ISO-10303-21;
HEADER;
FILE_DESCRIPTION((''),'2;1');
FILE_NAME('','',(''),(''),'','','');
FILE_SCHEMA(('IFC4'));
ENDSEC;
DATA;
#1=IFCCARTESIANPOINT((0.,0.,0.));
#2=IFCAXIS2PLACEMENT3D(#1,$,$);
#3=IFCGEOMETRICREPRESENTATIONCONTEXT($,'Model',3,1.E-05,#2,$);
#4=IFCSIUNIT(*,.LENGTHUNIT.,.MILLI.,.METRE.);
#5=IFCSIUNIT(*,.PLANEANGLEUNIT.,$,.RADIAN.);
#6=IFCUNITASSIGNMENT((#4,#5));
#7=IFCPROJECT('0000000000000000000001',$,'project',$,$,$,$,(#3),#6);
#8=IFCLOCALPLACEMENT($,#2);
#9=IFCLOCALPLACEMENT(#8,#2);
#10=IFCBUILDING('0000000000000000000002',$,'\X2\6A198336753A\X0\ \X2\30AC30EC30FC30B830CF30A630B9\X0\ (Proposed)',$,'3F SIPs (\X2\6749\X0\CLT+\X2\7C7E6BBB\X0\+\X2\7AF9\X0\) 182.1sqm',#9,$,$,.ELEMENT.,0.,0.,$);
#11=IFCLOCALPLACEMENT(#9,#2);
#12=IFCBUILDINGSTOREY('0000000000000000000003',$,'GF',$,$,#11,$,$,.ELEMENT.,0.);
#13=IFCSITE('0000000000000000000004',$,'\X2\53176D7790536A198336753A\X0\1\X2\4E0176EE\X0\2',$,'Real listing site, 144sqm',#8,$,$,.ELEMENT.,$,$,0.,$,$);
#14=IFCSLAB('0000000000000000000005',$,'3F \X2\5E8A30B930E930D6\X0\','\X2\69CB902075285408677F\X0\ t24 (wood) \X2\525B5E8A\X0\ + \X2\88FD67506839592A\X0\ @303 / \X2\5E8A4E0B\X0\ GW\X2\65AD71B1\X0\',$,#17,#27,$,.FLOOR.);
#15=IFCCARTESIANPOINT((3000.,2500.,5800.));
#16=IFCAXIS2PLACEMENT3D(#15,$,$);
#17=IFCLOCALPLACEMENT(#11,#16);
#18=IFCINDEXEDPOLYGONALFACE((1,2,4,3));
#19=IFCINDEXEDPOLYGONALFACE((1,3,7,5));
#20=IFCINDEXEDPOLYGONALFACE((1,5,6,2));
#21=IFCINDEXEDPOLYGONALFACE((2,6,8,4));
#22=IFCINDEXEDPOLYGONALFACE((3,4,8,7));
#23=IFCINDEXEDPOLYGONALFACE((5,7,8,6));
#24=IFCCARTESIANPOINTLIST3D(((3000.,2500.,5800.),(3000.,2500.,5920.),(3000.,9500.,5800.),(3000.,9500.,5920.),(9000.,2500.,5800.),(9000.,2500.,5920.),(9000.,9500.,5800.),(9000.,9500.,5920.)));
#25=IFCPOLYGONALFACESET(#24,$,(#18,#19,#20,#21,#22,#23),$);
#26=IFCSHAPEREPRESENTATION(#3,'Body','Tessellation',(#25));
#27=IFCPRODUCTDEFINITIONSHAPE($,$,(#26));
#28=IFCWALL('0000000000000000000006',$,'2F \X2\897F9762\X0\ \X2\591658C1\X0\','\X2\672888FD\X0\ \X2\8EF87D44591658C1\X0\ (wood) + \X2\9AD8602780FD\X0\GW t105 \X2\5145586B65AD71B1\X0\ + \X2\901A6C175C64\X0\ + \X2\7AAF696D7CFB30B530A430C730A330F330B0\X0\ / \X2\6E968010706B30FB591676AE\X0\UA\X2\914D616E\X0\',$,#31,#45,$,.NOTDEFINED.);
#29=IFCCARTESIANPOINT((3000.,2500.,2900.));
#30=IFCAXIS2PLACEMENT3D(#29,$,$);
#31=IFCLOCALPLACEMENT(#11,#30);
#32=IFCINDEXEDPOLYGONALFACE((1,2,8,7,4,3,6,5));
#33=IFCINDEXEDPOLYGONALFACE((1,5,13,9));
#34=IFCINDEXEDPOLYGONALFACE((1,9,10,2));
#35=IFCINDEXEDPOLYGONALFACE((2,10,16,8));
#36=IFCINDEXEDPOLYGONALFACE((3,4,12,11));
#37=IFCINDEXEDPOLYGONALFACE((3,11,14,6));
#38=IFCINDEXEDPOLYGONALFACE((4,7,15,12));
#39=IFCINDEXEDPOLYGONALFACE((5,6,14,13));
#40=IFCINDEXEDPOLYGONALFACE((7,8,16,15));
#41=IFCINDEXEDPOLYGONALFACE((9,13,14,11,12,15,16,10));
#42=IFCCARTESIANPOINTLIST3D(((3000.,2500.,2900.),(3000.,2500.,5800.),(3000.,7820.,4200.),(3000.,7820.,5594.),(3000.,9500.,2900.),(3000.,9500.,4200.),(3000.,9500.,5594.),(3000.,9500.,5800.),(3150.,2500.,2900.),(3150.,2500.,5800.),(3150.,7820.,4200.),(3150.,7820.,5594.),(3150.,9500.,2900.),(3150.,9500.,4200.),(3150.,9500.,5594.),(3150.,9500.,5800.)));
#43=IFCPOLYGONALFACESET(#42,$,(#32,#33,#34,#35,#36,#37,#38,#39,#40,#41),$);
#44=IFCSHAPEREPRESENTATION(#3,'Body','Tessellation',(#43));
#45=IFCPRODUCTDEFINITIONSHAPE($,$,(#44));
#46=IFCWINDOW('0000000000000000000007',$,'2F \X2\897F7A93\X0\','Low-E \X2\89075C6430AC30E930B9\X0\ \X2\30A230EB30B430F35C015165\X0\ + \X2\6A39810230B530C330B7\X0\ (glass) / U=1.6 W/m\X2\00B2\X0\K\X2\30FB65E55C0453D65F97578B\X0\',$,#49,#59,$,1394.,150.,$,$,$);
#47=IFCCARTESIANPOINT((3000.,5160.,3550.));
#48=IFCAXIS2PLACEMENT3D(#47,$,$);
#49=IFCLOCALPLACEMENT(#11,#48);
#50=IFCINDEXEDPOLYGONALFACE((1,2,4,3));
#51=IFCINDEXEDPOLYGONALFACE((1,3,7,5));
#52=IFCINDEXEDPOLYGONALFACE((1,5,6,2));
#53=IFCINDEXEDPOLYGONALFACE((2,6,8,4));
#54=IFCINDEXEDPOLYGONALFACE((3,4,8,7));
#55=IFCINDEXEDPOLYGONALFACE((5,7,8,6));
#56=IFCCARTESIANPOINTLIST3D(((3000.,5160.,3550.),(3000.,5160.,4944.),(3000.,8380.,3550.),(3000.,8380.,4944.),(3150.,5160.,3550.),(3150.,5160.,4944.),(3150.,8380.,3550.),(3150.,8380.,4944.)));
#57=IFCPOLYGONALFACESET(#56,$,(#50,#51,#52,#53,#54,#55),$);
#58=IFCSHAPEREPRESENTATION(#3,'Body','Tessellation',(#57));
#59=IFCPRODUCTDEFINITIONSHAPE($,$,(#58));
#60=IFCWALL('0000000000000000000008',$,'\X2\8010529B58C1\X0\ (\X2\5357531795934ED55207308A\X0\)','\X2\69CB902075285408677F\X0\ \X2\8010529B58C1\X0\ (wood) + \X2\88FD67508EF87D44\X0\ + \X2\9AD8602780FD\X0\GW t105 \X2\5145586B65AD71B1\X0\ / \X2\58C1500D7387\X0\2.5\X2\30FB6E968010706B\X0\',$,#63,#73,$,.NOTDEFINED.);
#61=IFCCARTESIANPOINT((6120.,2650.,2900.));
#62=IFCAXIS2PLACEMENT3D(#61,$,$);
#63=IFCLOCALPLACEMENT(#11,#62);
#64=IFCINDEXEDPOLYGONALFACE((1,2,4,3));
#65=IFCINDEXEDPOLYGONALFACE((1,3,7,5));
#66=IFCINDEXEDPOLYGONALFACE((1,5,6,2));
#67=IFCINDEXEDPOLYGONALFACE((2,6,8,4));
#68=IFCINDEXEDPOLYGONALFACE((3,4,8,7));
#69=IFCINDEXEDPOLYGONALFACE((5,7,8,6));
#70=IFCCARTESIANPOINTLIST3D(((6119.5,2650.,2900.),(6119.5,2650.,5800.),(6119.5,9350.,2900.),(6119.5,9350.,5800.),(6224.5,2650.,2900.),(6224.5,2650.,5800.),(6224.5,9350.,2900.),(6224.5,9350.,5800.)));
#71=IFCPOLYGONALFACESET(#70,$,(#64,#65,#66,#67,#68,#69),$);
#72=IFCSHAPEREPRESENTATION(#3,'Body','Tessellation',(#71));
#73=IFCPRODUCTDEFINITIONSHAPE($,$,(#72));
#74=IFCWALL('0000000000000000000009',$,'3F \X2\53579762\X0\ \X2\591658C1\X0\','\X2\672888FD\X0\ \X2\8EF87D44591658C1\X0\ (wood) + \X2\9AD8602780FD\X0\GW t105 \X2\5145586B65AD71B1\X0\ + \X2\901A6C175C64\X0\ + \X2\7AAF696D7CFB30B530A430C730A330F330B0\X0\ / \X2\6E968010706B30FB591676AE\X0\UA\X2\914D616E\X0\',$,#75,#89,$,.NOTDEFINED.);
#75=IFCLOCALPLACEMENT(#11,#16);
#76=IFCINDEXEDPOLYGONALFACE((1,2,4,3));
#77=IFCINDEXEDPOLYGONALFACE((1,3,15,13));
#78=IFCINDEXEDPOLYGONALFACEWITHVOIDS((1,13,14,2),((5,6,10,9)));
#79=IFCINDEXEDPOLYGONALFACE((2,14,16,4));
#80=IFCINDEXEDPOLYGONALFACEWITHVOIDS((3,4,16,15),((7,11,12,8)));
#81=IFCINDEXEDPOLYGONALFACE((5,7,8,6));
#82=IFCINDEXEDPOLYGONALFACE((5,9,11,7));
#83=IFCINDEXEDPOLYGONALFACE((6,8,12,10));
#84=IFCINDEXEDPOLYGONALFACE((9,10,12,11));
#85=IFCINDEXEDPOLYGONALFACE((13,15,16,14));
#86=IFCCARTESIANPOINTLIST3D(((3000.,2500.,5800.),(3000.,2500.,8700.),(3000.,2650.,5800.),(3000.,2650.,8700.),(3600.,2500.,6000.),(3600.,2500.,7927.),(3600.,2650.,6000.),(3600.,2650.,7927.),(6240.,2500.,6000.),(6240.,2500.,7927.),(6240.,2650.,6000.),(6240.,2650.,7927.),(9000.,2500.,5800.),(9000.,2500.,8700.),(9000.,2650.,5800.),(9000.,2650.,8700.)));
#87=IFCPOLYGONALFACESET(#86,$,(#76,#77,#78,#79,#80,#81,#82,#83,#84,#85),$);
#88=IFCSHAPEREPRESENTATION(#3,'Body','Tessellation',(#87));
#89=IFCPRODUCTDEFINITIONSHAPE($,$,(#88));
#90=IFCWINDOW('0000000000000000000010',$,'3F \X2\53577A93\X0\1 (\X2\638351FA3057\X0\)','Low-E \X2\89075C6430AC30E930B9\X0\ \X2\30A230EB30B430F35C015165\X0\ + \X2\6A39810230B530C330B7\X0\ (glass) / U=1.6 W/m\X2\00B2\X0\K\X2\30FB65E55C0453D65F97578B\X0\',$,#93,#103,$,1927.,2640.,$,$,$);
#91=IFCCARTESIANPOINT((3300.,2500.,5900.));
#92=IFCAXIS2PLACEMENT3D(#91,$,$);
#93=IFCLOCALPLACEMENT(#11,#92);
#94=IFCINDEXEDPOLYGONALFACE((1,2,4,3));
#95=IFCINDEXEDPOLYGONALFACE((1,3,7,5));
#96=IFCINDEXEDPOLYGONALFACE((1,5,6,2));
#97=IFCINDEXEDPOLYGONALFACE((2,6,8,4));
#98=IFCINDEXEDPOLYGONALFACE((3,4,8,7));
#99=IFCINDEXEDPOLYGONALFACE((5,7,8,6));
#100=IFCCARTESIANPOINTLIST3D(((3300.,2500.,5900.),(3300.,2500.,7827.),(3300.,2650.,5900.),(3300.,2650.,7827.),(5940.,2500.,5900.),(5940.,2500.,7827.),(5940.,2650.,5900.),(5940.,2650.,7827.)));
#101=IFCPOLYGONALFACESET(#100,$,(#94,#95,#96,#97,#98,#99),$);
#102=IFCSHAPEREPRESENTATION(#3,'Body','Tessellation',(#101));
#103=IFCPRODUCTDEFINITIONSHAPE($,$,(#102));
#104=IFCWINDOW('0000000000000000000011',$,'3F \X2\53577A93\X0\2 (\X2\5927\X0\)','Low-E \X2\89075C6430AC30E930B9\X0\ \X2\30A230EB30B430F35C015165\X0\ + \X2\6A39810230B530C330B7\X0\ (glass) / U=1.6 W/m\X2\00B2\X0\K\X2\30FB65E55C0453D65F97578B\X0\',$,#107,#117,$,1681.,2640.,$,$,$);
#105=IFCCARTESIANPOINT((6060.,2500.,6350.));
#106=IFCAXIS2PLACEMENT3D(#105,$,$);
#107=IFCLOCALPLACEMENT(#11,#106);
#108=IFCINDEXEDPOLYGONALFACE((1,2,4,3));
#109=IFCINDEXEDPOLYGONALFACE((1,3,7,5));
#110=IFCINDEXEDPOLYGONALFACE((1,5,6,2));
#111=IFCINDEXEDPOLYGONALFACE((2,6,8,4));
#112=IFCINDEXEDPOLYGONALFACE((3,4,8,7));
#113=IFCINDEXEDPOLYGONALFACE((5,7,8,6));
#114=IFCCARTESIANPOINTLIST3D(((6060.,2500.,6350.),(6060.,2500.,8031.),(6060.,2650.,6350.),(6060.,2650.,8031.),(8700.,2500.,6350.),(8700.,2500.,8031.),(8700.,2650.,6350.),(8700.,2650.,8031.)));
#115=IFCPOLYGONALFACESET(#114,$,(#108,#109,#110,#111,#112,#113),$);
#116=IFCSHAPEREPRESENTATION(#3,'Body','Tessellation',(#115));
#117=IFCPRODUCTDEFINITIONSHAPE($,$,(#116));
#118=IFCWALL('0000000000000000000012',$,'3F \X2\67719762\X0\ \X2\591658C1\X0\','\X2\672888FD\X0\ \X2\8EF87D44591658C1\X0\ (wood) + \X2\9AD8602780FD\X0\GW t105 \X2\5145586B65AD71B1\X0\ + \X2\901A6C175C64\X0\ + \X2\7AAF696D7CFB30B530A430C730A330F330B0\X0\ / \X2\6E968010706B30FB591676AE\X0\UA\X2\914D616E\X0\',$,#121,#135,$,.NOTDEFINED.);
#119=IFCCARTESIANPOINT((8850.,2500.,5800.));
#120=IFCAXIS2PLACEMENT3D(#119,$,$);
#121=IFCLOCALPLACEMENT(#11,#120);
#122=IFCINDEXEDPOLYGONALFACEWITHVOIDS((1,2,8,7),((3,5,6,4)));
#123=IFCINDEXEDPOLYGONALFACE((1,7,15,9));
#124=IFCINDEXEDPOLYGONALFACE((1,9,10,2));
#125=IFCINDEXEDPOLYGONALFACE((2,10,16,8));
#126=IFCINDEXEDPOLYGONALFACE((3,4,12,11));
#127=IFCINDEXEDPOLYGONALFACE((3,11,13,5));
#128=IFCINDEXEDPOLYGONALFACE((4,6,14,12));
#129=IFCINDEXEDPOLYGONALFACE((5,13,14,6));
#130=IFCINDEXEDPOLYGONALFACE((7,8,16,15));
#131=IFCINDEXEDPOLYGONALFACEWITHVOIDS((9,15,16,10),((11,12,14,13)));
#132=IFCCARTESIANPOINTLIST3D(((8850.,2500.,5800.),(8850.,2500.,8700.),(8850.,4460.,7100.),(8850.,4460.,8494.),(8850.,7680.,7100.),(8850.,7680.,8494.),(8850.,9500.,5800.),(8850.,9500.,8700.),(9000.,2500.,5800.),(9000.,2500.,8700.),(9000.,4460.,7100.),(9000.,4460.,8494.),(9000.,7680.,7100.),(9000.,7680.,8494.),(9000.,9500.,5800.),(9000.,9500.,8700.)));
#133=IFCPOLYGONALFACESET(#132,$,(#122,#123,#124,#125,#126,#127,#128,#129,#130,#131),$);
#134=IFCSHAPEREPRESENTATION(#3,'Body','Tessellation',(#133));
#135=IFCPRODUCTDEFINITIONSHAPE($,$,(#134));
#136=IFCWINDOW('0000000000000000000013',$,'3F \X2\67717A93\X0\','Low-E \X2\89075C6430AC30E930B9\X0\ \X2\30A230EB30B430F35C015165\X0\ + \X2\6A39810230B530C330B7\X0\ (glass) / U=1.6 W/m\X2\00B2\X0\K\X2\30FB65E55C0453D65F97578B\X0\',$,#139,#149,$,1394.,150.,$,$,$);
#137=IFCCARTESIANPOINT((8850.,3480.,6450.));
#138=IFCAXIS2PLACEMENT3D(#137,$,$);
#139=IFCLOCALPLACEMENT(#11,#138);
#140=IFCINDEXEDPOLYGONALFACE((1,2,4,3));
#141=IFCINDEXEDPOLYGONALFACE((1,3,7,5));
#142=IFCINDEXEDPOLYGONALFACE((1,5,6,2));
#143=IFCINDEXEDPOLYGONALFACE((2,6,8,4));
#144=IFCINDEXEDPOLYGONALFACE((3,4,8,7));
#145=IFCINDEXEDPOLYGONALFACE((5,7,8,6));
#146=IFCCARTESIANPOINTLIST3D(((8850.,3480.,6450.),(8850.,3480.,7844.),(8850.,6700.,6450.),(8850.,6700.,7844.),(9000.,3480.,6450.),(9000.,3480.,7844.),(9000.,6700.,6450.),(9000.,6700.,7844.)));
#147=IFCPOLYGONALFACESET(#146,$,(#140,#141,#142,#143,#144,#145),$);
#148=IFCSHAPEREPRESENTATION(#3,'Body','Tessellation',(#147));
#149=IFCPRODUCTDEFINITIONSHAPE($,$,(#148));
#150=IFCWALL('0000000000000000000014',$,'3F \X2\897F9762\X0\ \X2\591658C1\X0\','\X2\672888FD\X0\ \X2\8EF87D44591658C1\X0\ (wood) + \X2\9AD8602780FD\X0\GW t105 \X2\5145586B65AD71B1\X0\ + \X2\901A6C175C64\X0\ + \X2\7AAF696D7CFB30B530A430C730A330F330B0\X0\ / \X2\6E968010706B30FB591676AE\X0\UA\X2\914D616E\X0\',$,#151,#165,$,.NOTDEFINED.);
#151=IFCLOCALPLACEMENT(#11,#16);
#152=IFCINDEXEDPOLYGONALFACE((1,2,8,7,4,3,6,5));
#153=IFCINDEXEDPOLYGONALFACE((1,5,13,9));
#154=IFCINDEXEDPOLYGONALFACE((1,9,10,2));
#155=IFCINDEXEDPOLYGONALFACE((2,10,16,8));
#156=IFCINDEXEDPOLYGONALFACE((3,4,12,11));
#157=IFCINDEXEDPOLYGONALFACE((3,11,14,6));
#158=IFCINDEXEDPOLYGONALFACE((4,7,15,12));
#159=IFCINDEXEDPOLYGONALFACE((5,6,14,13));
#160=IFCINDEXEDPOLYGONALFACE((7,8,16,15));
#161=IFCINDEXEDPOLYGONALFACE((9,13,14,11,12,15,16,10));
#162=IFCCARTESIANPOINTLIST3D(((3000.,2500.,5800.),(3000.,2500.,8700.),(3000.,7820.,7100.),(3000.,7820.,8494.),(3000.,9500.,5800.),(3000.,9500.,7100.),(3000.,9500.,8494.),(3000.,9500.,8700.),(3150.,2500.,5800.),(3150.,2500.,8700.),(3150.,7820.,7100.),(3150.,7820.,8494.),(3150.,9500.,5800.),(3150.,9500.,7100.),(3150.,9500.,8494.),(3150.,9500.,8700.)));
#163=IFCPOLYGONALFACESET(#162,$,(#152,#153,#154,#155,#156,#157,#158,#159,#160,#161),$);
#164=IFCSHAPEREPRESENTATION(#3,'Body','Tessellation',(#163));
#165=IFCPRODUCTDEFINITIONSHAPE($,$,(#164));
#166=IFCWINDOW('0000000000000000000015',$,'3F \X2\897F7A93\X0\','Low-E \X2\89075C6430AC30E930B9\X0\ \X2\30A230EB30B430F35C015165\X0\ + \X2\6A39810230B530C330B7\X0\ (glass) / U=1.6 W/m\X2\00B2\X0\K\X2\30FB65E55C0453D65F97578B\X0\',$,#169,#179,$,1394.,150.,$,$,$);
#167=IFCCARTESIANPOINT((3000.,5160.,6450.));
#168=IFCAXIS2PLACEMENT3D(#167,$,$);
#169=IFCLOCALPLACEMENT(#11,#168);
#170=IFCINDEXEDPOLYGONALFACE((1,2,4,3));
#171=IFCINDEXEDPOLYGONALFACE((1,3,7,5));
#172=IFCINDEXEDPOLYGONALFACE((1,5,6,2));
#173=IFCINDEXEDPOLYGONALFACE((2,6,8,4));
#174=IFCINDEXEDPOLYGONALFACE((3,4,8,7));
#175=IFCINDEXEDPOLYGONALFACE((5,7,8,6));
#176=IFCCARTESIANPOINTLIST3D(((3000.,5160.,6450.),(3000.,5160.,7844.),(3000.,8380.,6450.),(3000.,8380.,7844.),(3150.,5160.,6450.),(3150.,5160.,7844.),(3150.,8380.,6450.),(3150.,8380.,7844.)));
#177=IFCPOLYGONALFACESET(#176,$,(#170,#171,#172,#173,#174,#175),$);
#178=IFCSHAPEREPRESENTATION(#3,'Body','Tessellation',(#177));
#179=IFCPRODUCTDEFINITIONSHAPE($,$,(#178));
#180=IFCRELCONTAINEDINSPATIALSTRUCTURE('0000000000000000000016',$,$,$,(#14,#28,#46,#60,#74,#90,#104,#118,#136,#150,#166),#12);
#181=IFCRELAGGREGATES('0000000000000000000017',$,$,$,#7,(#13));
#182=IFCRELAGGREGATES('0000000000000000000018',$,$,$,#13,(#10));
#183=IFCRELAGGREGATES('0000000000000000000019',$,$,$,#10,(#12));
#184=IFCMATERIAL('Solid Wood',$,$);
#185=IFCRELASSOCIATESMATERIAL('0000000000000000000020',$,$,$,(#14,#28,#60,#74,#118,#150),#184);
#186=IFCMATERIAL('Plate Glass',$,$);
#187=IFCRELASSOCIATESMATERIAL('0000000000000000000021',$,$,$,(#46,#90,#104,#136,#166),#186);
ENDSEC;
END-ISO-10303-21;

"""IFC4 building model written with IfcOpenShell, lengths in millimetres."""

from ifc_helpers import new_model, si_unit, frame, frame_2d, origin, place, context, project, spatial, rectangle, extrude, material, element, fill, save


model = new_model("IFC4")

# Units and contexts
model_context = context("Model", 3, precision=1e-05, world=origin())
ifc_project = project(units=[si_unit("LENGTHUNIT", "METRE", prefix="MILLI"), si_unit("PLANEANGLEUNIT", "RADIAN")], contexts=[model_context])

# Site, building, storey
site_placement = place(None, origin())
site = spatial("IfcSite", under=ifc_project, at=site_placement, Name="北海道標茶町1丁目2", ObjectType="Real listing site, 144sqm", CompositionType="ELEMENT", RefElevation=0.0)
building_placement = place(site_placement, origin())
building = spatial("IfcBuilding", under=site, at=building_placement, Name="標茶町 ガレージハウス (Proposed)", ObjectType="3F SIPs (杉CLT+籾殻+竹) 182.1sqm", CompositionType="ELEMENT", ElevationOfRefHeight=0.0, ElevationOfTerrain=0.0)
storey_placement = place(building_placement, origin())
storey = spatial("IfcBuildingStorey", under=building, at=storey_placement, Name="GF", CompositionType="ELEMENT", Elevation=0.0)

# Slab
ifc_material_1 = material(Name="Solid Wood")
slab_placement = place(storey_placement, frame((3000.0, 2500.0, 5800.0)))
element("IfcSlab", 1, at=slab_placement, inside=storey, material=ifc_material_1, Name="3F 床スラブ", Description="構造用合板 t24 (wood) 剛床 + 製材根太 @303 / 床下 GW断熱", PredefinedType="FLOOR", context=model_context, shape_type="SweptSolid", body=[
    extrude(rectangle(XDim=6000.0, YDim=7000.0, at=frame_2d((3000.0, 3500.0))), frame((3000.0, 2500.0, 5800.0)), (0.0, 0.0, 1.0), 120.0),
])

# Wall, opening, window
wall_1_placement = place(storey_placement, frame((3000.0, 2500.0, 2900.0)))
wall_1 = element("IfcWall", 2, at=wall_1_placement, inside=storey, material=ifc_material_1, Name="2F 西面 外壁", Description="木製 軸組外壁 (wood) + 高性能GW t105 充填断熱 + 通気層 + 窯業系サイディング / 準耐火・外皮UA配慮", PredefinedType="NOTDEFINED", context=model_context, shape_type="SweptSolid", body=[
    extrude(rectangle(XDim=150.0, YDim=7000.0, at=frame_2d((75.0, 3500.0))), frame((3000.0, 2500.0, 2900.0)), (0.0, 0.0, 1.0), 2900.0),
])
opening_1_placement = place(storey_placement, frame((3000.0, 5160.0, 3550.0)))
opening_1 = element("IfcOpeningElement", 3, at=opening_1_placement, cuts=wall_1, PredefinedType="NOTDEFINED", context=model_context, shape_type="SweptSolid", body=[
    extrude(rectangle(XDim=150.0, YDim=3220.0, at=frame_2d((75.0, 1610.0))), frame((3000.0, 5160.0, 3550.0)), (0.0, 0.0, 1.0), 1394.0),
])
ifc_material_2 = material(Name="Plate Glass")
window_1_placement = place(storey_placement, frame((3000.0, 5160.0, 3550.0)))
window_1 = element("IfcWindow", 4, at=window_1_placement, inside=storey, material=ifc_material_2, Name="2F 西窓", Description="Low-E 複層ガラス アルゴン封入 + 樹脂サッシ (glass) / U=1.6 W/m²K・日射取得型", OverallHeight=1394.0, OverallWidth=150.0, context=model_context, shape_type="SweptSolid", body=[
    extrude(rectangle(XDim=150.0, YDim=3220.0, at=frame_2d((75.0, 1610.0))), frame((3000.0, 5160.0, 3550.0)), (0.0, 0.0, 1.0), 1394.0),
])
fill(opening_1, window_1)

# Wall
wall_2_placement = place(storey_placement, frame((6120.0, 2650.0, 2900.0)))
element("IfcWall", 5, at=wall_2_placement, inside=storey, material=ifc_material_1, Name="耐力壁 (南北間仕切り)", Description="構造用合板 耐力壁 (wood) + 製材軸組 + 高性能GW t105 充填断熱 / 壁倍率2.5・準耐火", PredefinedType="NOTDEFINED", context=model_context, shape_type="SweptSolid", body=[
    extrude(rectangle(XDim=105.0, YDim=6700.0, at=frame_2d((52.0, 3350.0))), frame((6120.0, 2650.0, 2900.0)), (0.0, 0.0, 1.0), 2900.0),
])

# Wall, openings, windows
wall_3_placement = place(storey_placement, frame((3000.0, 2500.0, 5800.0)))
wall_3 = element("IfcWall", 6, at=wall_3_placement, inside=storey, material=ifc_material_1, Name="3F 南面 外壁", Description="木製 軸組外壁 (wood) + 高性能GW t105 充填断熱 + 通気層 + 窯業系サイディング / 準耐火・外皮UA配慮", PredefinedType="NOTDEFINED", context=model_context, shape_type="SweptSolid", body=[
    extrude(rectangle(XDim=6000.0, YDim=150.0, at=frame_2d((3000.0, 75.0))), frame((3000.0, 2500.0, 5800.0)), (0.0, 0.0, 1.0), 2900.0),
])
opening_2_placement = place(storey_placement, frame((3300.0, 2500.0, 5900.0)))
opening_2 = element("IfcOpeningElement", 7, at=opening_2_placement, cuts=wall_3, PredefinedType="NOTDEFINED", context=model_context, shape_type="SweptSolid", body=[
    extrude(rectangle(XDim=2640.0, YDim=150.0, at=frame_2d((1320.0, 75.0))), frame((3300.0, 2500.0, 5900.0)), (0.0, 0.0, 1.0), 1927.0),
])
opening_3_placement = place(storey_placement, frame((6060.0, 2500.0, 6350.0)))
opening_3 = element("IfcOpeningElement", 8, at=opening_3_placement, cuts=wall_3, PredefinedType="NOTDEFINED", context=model_context, shape_type="SweptSolid", body=[
    extrude(rectangle(XDim=2640.0, YDim=150.0, at=frame_2d((1320.0, 75.0))), frame((6060.0, 2500.0, 6350.0)), (0.0, 0.0, 1.0), 1681.0),
])
window_2_placement = place(storey_placement, frame((3300.0, 2500.0, 5900.0)))
window_2 = element("IfcWindow", 9, at=window_2_placement, inside=storey, material=ifc_material_2, Name="3F 南窓1 (掃出し)", Description="Low-E 複層ガラス アルゴン封入 + 樹脂サッシ (glass) / U=1.6 W/m²K・日射取得型", OverallHeight=1927.0, OverallWidth=2640.0, context=model_context, shape_type="SweptSolid", body=[
    extrude(rectangle(XDim=2640.0, YDim=150.0, at=frame_2d((1320.0, 75.0))), frame((3300.0, 2500.0, 5900.0)), (0.0, 0.0, 1.0), 1927.0),
])
fill(opening_2, window_2)
window_3_placement = place(storey_placement, frame((6060.0, 2500.0, 6350.0)))
window_3 = element("IfcWindow", 10, at=window_3_placement, inside=storey, material=ifc_material_2, Name="3F 南窓2 (大)", Description="Low-E 複層ガラス アルゴン封入 + 樹脂サッシ (glass) / U=1.6 W/m²K・日射取得型", OverallHeight=1681.0, OverallWidth=2640.0, context=model_context, shape_type="SweptSolid", body=[
    extrude(rectangle(XDim=2640.0, YDim=150.0, at=frame_2d((1320.0, 75.0))), frame((6060.0, 2500.0, 6350.0)), (0.0, 0.0, 1.0), 1681.0),
])
fill(opening_3, window_3)

# Walls, openings, windows
wall_4_placement = place(storey_placement, frame((8850.0, 2500.0, 5800.0)))
wall_4 = element("IfcWall", 11, at=wall_4_placement, inside=storey, material=ifc_material_1, Name="3F 東面 外壁", Description="木製 軸組外壁 (wood) + 高性能GW t105 充填断熱 + 通気層 + 窯業系サイディング / 準耐火・外皮UA配慮", PredefinedType="NOTDEFINED", context=model_context, shape_type="SweptSolid", body=[
    extrude(rectangle(XDim=150.0, YDim=7000.0, at=frame_2d((75.0, 3500.0))), frame((8850.0, 2500.0, 5800.0)), (0.0, 0.0, 1.0), 2900.0),
])
opening_4_placement = place(storey_placement, frame((8850.0, 3480.0, 6450.0)))
opening_4 = element("IfcOpeningElement", 12, at=opening_4_placement, cuts=wall_4, PredefinedType="NOTDEFINED", context=model_context, shape_type="SweptSolid", body=[
    extrude(rectangle(XDim=150.0, YDim=3220.0, at=frame_2d((75.0, 1610.0))), frame((8850.0, 3480.0, 6450.0)), (0.0, 0.0, 1.0), 1394.0),
])
window_4_placement = place(storey_placement, frame((8850.0, 3480.0, 6450.0)))
window_4 = element("IfcWindow", 13, at=window_4_placement, inside=storey, material=ifc_material_2, Name="3F 東窓", Description="Low-E 複層ガラス アルゴン封入 + 樹脂サッシ (glass) / U=1.6 W/m²K・日射取得型", OverallHeight=1394.0, OverallWidth=150.0, context=model_context, shape_type="SweptSolid", body=[
    extrude(rectangle(XDim=150.0, YDim=3220.0, at=frame_2d((75.0, 1610.0))), frame((8850.0, 3480.0, 6450.0)), (0.0, 0.0, 1.0), 1394.0),
])
fill(opening_4, window_4)
wall_5_placement = place(storey_placement, frame((3000.0, 2500.0, 5800.0)))
wall_5 = element("IfcWall", 14, at=wall_5_placement, inside=storey, material=ifc_material_1, Name="3F 西面 外壁", Description="木製 軸組外壁 (wood) + 高性能GW t105 充填断熱 + 通気層 + 窯業系サイディング / 準耐火・外皮UA配慮", PredefinedType="NOTDEFINED", context=model_context, shape_type="SweptSolid", body=[
    extrude(rectangle(XDim=150.0, YDim=7000.0, at=frame_2d((75.0, 3500.0))), frame((3000.0, 2500.0, 5800.0)), (0.0, 0.0, 1.0), 2900.0),
])
opening_5_placement = place(storey_placement, frame((3000.0, 5160.0, 6450.0)))
opening_5 = element("IfcOpeningElement", 15, at=opening_5_placement, cuts=wall_5, PredefinedType="NOTDEFINED", context=model_context, shape_type="SweptSolid", body=[
    extrude(rectangle(XDim=150.0, YDim=3220.0, at=frame_2d((75.0, 1610.0))), frame((3000.0, 5160.0, 6450.0)), (0.0, 0.0, 1.0), 1394.0),
])
window_5_placement = place(storey_placement, frame((3000.0, 5160.0, 6450.0)))
window_5 = element("IfcWindow", 16, at=window_5_placement, inside=storey, material=ifc_material_2, Name="3F 西窓", Description="Low-E 複層ガラス アルゴン封入 + 樹脂サッシ (glass) / U=1.6 W/m²K・日射取得型", OverallHeight=1394.0, OverallWidth=150.0, context=model_context, shape_type="SweptSolid", body=[
    extrude(rectangle(XDim=150.0, YDim=3220.0, at=frame_2d((75.0, 1610.0))), frame((3000.0, 5160.0, 6450.0)), (0.0, 0.0, 1.0), 1394.0),
])
fill(opening_5, window_5)

save(model, "model.ifc")
